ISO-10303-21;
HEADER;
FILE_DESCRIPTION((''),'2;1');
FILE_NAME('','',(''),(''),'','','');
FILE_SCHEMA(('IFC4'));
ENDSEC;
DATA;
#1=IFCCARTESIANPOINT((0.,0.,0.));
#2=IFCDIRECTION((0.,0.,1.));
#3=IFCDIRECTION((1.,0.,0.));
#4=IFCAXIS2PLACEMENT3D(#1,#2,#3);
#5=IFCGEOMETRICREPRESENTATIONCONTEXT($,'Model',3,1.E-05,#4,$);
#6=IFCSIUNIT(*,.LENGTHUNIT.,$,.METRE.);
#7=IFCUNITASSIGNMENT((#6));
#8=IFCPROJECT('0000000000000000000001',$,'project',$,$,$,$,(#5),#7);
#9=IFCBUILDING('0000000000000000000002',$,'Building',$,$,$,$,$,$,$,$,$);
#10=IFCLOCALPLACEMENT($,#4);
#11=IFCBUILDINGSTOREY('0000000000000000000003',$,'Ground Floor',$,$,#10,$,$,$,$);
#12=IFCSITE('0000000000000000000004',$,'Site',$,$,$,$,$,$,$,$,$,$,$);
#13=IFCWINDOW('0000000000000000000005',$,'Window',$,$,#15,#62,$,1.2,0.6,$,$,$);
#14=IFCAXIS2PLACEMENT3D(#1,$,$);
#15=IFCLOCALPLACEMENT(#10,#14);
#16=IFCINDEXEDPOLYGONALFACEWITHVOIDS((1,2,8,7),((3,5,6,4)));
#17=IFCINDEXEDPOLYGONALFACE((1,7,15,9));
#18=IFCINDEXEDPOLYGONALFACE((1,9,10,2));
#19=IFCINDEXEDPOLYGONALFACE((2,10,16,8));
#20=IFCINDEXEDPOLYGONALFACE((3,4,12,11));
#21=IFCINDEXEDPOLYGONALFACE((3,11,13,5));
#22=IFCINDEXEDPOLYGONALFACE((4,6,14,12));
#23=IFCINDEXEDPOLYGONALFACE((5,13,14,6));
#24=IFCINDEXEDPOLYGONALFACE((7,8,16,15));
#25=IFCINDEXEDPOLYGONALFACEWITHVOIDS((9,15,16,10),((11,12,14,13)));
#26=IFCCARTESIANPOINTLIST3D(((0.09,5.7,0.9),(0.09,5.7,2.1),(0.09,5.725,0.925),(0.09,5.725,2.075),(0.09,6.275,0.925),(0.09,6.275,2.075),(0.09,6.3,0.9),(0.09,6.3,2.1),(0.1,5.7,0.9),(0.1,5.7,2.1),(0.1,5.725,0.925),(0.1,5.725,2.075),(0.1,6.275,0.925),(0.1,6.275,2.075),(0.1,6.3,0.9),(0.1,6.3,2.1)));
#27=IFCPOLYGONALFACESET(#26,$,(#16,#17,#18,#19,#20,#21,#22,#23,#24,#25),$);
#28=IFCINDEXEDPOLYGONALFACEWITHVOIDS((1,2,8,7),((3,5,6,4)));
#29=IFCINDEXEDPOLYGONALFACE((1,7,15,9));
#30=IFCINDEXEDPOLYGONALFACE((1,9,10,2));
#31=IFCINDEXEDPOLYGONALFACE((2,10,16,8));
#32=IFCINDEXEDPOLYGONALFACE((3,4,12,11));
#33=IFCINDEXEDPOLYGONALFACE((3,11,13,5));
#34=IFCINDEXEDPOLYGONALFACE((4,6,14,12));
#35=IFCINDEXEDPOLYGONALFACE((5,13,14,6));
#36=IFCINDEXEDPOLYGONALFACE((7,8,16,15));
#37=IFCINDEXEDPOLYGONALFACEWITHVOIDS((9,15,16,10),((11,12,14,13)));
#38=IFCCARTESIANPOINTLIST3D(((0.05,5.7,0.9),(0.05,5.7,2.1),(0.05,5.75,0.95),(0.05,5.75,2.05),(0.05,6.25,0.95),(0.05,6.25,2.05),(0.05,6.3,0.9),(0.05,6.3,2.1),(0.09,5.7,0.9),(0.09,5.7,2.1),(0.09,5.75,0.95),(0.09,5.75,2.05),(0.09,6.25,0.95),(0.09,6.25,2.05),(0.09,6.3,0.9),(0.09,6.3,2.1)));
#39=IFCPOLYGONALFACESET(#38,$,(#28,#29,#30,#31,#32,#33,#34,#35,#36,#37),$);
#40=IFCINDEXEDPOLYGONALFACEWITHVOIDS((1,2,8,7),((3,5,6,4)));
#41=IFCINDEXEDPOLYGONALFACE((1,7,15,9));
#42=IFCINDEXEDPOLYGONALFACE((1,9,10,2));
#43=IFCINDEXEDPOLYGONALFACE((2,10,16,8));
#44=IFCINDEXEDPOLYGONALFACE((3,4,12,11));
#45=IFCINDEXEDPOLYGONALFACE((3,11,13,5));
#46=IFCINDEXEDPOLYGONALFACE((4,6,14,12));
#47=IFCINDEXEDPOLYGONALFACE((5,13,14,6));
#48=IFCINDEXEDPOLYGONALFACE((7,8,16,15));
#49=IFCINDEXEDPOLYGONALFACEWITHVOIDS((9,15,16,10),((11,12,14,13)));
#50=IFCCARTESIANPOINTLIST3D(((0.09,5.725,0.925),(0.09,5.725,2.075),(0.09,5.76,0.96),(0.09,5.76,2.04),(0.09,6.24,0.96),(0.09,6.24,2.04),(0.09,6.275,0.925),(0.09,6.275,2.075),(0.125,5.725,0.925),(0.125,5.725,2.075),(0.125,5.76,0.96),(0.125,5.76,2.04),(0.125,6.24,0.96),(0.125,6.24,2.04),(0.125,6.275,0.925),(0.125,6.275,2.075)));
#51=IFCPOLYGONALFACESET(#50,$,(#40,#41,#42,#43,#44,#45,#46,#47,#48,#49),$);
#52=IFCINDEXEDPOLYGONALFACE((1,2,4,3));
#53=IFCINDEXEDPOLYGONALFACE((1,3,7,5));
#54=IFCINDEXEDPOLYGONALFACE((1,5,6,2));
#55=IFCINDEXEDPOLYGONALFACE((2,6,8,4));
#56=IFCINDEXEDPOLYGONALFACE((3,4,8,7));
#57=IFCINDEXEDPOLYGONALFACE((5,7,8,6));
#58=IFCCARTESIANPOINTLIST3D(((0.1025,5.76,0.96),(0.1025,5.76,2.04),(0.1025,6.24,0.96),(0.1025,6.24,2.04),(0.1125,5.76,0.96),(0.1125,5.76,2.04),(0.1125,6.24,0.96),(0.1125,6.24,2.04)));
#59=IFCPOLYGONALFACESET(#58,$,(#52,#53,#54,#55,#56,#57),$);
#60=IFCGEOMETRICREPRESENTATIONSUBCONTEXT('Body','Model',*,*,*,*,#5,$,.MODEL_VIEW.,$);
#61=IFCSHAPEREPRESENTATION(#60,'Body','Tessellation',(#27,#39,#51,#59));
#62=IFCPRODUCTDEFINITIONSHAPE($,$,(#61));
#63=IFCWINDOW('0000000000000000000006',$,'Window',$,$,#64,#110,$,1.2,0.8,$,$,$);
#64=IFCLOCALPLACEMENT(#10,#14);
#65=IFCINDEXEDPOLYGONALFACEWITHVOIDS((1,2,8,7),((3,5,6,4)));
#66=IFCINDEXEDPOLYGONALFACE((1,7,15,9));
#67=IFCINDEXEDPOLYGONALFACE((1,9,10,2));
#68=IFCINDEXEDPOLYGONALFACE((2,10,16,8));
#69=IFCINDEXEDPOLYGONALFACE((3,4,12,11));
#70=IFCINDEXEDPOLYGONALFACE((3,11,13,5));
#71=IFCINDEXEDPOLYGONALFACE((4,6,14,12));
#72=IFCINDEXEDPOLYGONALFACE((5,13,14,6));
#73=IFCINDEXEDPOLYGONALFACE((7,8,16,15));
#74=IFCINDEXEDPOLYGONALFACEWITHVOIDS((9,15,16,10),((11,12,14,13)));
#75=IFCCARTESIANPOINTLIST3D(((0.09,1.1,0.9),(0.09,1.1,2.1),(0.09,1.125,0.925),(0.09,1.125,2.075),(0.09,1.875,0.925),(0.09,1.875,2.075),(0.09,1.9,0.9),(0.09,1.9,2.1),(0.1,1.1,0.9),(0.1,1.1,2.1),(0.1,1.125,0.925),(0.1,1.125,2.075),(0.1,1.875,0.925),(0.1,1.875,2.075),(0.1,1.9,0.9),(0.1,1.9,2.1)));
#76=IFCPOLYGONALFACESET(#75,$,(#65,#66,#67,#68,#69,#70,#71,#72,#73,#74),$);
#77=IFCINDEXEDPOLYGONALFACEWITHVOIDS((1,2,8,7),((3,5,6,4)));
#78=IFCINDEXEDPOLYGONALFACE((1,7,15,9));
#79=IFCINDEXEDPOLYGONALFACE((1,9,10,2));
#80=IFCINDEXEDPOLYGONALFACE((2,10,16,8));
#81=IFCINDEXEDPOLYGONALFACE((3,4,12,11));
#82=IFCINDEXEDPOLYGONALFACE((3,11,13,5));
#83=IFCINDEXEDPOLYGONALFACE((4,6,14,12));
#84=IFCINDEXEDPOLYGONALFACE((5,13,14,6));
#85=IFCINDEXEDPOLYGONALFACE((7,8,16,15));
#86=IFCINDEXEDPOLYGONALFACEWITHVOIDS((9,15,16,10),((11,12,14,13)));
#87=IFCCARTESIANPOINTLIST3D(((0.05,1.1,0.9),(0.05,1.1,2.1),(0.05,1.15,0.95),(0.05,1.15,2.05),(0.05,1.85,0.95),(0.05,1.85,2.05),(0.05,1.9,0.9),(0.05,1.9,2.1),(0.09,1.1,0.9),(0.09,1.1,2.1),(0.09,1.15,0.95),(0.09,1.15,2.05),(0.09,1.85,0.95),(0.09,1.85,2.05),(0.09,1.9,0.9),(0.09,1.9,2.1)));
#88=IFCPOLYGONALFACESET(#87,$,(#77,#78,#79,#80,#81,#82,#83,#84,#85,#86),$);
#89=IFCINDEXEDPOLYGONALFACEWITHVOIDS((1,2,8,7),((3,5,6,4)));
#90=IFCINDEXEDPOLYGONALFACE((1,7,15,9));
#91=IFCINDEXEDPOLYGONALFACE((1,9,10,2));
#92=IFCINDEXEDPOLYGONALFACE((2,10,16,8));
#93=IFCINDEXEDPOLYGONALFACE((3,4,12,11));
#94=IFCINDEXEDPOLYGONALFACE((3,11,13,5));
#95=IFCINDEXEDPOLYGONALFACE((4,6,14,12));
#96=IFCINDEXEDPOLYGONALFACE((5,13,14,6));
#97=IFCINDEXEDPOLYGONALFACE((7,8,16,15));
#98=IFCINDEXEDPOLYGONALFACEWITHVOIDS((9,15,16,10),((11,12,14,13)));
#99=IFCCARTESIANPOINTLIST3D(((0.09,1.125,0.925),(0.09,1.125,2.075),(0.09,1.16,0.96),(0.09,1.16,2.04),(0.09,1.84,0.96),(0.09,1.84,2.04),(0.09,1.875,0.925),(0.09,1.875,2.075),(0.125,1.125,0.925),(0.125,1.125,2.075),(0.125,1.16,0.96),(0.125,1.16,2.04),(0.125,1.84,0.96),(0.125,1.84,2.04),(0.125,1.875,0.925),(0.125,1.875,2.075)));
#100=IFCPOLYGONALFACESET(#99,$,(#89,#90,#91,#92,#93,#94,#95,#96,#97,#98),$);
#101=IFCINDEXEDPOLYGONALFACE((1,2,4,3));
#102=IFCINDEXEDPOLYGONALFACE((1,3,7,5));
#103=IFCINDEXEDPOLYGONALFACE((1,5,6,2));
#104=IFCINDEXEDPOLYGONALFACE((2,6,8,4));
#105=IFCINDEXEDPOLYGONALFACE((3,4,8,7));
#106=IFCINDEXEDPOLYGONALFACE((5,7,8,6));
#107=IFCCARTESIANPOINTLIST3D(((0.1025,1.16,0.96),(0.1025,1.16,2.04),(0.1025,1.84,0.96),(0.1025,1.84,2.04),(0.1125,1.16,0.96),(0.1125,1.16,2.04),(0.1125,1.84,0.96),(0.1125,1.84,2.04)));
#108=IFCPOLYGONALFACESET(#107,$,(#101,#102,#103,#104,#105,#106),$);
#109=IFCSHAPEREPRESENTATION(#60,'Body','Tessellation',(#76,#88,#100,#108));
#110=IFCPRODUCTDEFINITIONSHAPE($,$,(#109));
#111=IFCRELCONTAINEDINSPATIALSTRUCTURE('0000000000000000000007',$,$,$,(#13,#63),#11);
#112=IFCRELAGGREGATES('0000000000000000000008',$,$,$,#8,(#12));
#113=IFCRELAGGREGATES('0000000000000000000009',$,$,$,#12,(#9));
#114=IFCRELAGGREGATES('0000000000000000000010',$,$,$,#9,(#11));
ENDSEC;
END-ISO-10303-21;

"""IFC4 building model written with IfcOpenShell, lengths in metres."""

from ifc_helpers import new_model, si_unit, frame, origin_with_axes, place, context, subcontext, project, spatial, line, indexed_curve, outline, extrude, element, save


model = new_model("IFC4")

# Units and contexts
model_context = context("Model", 3, precision=1e-05, world=origin_with_axes())
body_context = subcontext(model_context, "Body", "Model", "MODEL_VIEW")
ifc_project = project(units=[si_unit("LENGTHUNIT", "METRE")], contexts=[model_context])

# Site, building, storey
site = spatial("IfcSite", under=ifc_project, Name="Site")
building = spatial("IfcBuilding", under=site, Name="Building")
storey_placement = place(None, origin_with_axes())
storey = spatial("IfcBuildingStorey", under=building, at=storey_placement, Name="Ground Floor")

# Windows
window_1_placement = place(storey_placement, frame((0.0, 6.3, 0.9), z_axis=(0.0, 0.0, 1.0), x_axis=(0.0, -1.0, 0.0)))
element("IfcWindow", 1, at=window_1_placement, inside=storey, Name="Window", OverallHeight=1.2, OverallWidth=0.6, context=body_context, shape_type="SweptSolid", body=[
    extrude(outline(indexed_curve([(0.0, 0.0), (0.6, 0.0), (0.6, 1.2), (0.0, 1.2)], segments=[line(1, 2, 3, 4, 1)]), holes=[indexed_curve([(0.025, 0.025), (0.575, 0.025), (0.575, 1.175), (0.025, 1.175)], segments=[line(1, 2, 3, 4, 1)])]), frame((0.0, 0.09, 0.0), z_axis=(0.0, -1.0, 0.0), x_axis=(1.0, 0.0, 0.0)), (0.0, 0.0, -1.0), 0.01),
    extrude(outline(indexed_curve([(0.0, 0.0), (0.6, 0.0), (0.6, 1.2), (0.0, 1.2)], segments=[line(1, 2, 3, 4, 1)]), holes=[indexed_curve([(0.05, 0.05), (0.55, 0.05), (0.55, 1.15), (0.05, 1.15)], segments=[line(1, 2, 3, 4, 1)])]), frame((0.0, 0.05, 0.0), z_axis=(0.0, -1.0, 0.0), x_axis=(1.0, 0.0, 0.0)), (0.0, 0.0, -1.0), 0.04),
    extrude(outline(indexed_curve([(0.0, 0.0), (0.55, 0.0), (0.55, 1.15), (0.0, 1.15)], segments=[line(1, 2, 3, 4, 1)]), holes=[indexed_curve([(0.035, 0.035), (0.515, 0.035), (0.515, 1.115), (0.035, 1.115)], segments=[line(1, 2, 3, 4, 1)])]), frame((0.025, 0.09, 0.025), z_axis=(0.0, -1.0, 0.0), x_axis=(1.0, 0.0, 0.0)), (0.0, 0.0, -1.0), 0.035),
    extrude(outline(indexed_curve([(0.035, 0.035), (0.515, 0.035), (0.515, 1.115), (0.035, 1.115)], segments=[line(1, 2, 3, 4, 1)])), frame((0.025, 0.1025, 0.025), z_axis=(0.0, -1.0, 0.0), x_axis=(1.0, 0.0, 0.0)), (0.0, 0.0, -1.0), 0.01),
])
window_2_placement = place(storey_placement, frame((0.0, 1.9, 0.9), z_axis=(0.0, 0.0, 1.0), x_axis=(0.0, -1.0, 0.0)))
element("IfcWindow", 2, at=window_2_placement, inside=storey, Name="Window", OverallHeight=1.2, OverallWidth=0.8, context=body_context, shape_type="SweptSolid", body=[
    extrude(outline(indexed_curve([(0.0, 0.0), (0.8, 0.0), (0.8, 1.2), (0.0, 1.2)], segments=[line(1, 2, 3, 4, 1)]), holes=[indexed_curve([(0.025, 0.025), (0.775, 0.025), (0.775, 1.175), (0.025, 1.175)], segments=[line(1, 2, 3, 4, 1)])]), frame((0.0, 0.09, 0.0), z_axis=(0.0, -1.0, 0.0), x_axis=(1.0, 0.0, 0.0)), (0.0, 0.0, -1.0), 0.01),
    extrude(outline(indexed_curve([(0.0, 0.0), (0.8, 0.0), (0.8, 1.2), (0.0, 1.2)], segments=[line(1, 2, 3, 4, 1)]), holes=[indexed_curve([(0.05, 0.05), (0.75, 0.05), (0.75, 1.15), (0.05, 1.15)], segments=[line(1, 2, 3, 4, 1)])]), frame((0.0, 0.05, 0.0), z_axis=(0.0, -1.0, 0.0), x_axis=(1.0, 0.0, 0.0)), (0.0, 0.0, -1.0), 0.04),
    extrude(outline(indexed_curve([(0.0, 0.0), (0.75, 0.0), (0.75, 1.15), (0.0, 1.15)], segments=[line(1, 2, 3, 4, 1)]), holes=[indexed_curve([(0.035, 0.035), (0.715, 0.035), (0.715, 1.115), (0.035, 1.115)], segments=[line(1, 2, 3, 4, 1)])]), frame((0.025, 0.09, 0.025), z_axis=(0.0, -1.0, 0.0), x_axis=(1.0, 0.0, 0.0)), (0.0, 0.0, -1.0), 0.035),
    extrude(outline(indexed_curve([(0.035, 0.035), (0.715, 0.035), (0.715, 1.115), (0.035, 1.115)], segments=[line(1, 2, 3, 4, 1)])), frame((0.025, 0.1025, 0.025), z_axis=(0.0, -1.0, 0.0), x_axis=(1.0, 0.0, 0.0)), (0.0, 0.0, -1.0), 0.01),
])

save(model, "model.ifc")
